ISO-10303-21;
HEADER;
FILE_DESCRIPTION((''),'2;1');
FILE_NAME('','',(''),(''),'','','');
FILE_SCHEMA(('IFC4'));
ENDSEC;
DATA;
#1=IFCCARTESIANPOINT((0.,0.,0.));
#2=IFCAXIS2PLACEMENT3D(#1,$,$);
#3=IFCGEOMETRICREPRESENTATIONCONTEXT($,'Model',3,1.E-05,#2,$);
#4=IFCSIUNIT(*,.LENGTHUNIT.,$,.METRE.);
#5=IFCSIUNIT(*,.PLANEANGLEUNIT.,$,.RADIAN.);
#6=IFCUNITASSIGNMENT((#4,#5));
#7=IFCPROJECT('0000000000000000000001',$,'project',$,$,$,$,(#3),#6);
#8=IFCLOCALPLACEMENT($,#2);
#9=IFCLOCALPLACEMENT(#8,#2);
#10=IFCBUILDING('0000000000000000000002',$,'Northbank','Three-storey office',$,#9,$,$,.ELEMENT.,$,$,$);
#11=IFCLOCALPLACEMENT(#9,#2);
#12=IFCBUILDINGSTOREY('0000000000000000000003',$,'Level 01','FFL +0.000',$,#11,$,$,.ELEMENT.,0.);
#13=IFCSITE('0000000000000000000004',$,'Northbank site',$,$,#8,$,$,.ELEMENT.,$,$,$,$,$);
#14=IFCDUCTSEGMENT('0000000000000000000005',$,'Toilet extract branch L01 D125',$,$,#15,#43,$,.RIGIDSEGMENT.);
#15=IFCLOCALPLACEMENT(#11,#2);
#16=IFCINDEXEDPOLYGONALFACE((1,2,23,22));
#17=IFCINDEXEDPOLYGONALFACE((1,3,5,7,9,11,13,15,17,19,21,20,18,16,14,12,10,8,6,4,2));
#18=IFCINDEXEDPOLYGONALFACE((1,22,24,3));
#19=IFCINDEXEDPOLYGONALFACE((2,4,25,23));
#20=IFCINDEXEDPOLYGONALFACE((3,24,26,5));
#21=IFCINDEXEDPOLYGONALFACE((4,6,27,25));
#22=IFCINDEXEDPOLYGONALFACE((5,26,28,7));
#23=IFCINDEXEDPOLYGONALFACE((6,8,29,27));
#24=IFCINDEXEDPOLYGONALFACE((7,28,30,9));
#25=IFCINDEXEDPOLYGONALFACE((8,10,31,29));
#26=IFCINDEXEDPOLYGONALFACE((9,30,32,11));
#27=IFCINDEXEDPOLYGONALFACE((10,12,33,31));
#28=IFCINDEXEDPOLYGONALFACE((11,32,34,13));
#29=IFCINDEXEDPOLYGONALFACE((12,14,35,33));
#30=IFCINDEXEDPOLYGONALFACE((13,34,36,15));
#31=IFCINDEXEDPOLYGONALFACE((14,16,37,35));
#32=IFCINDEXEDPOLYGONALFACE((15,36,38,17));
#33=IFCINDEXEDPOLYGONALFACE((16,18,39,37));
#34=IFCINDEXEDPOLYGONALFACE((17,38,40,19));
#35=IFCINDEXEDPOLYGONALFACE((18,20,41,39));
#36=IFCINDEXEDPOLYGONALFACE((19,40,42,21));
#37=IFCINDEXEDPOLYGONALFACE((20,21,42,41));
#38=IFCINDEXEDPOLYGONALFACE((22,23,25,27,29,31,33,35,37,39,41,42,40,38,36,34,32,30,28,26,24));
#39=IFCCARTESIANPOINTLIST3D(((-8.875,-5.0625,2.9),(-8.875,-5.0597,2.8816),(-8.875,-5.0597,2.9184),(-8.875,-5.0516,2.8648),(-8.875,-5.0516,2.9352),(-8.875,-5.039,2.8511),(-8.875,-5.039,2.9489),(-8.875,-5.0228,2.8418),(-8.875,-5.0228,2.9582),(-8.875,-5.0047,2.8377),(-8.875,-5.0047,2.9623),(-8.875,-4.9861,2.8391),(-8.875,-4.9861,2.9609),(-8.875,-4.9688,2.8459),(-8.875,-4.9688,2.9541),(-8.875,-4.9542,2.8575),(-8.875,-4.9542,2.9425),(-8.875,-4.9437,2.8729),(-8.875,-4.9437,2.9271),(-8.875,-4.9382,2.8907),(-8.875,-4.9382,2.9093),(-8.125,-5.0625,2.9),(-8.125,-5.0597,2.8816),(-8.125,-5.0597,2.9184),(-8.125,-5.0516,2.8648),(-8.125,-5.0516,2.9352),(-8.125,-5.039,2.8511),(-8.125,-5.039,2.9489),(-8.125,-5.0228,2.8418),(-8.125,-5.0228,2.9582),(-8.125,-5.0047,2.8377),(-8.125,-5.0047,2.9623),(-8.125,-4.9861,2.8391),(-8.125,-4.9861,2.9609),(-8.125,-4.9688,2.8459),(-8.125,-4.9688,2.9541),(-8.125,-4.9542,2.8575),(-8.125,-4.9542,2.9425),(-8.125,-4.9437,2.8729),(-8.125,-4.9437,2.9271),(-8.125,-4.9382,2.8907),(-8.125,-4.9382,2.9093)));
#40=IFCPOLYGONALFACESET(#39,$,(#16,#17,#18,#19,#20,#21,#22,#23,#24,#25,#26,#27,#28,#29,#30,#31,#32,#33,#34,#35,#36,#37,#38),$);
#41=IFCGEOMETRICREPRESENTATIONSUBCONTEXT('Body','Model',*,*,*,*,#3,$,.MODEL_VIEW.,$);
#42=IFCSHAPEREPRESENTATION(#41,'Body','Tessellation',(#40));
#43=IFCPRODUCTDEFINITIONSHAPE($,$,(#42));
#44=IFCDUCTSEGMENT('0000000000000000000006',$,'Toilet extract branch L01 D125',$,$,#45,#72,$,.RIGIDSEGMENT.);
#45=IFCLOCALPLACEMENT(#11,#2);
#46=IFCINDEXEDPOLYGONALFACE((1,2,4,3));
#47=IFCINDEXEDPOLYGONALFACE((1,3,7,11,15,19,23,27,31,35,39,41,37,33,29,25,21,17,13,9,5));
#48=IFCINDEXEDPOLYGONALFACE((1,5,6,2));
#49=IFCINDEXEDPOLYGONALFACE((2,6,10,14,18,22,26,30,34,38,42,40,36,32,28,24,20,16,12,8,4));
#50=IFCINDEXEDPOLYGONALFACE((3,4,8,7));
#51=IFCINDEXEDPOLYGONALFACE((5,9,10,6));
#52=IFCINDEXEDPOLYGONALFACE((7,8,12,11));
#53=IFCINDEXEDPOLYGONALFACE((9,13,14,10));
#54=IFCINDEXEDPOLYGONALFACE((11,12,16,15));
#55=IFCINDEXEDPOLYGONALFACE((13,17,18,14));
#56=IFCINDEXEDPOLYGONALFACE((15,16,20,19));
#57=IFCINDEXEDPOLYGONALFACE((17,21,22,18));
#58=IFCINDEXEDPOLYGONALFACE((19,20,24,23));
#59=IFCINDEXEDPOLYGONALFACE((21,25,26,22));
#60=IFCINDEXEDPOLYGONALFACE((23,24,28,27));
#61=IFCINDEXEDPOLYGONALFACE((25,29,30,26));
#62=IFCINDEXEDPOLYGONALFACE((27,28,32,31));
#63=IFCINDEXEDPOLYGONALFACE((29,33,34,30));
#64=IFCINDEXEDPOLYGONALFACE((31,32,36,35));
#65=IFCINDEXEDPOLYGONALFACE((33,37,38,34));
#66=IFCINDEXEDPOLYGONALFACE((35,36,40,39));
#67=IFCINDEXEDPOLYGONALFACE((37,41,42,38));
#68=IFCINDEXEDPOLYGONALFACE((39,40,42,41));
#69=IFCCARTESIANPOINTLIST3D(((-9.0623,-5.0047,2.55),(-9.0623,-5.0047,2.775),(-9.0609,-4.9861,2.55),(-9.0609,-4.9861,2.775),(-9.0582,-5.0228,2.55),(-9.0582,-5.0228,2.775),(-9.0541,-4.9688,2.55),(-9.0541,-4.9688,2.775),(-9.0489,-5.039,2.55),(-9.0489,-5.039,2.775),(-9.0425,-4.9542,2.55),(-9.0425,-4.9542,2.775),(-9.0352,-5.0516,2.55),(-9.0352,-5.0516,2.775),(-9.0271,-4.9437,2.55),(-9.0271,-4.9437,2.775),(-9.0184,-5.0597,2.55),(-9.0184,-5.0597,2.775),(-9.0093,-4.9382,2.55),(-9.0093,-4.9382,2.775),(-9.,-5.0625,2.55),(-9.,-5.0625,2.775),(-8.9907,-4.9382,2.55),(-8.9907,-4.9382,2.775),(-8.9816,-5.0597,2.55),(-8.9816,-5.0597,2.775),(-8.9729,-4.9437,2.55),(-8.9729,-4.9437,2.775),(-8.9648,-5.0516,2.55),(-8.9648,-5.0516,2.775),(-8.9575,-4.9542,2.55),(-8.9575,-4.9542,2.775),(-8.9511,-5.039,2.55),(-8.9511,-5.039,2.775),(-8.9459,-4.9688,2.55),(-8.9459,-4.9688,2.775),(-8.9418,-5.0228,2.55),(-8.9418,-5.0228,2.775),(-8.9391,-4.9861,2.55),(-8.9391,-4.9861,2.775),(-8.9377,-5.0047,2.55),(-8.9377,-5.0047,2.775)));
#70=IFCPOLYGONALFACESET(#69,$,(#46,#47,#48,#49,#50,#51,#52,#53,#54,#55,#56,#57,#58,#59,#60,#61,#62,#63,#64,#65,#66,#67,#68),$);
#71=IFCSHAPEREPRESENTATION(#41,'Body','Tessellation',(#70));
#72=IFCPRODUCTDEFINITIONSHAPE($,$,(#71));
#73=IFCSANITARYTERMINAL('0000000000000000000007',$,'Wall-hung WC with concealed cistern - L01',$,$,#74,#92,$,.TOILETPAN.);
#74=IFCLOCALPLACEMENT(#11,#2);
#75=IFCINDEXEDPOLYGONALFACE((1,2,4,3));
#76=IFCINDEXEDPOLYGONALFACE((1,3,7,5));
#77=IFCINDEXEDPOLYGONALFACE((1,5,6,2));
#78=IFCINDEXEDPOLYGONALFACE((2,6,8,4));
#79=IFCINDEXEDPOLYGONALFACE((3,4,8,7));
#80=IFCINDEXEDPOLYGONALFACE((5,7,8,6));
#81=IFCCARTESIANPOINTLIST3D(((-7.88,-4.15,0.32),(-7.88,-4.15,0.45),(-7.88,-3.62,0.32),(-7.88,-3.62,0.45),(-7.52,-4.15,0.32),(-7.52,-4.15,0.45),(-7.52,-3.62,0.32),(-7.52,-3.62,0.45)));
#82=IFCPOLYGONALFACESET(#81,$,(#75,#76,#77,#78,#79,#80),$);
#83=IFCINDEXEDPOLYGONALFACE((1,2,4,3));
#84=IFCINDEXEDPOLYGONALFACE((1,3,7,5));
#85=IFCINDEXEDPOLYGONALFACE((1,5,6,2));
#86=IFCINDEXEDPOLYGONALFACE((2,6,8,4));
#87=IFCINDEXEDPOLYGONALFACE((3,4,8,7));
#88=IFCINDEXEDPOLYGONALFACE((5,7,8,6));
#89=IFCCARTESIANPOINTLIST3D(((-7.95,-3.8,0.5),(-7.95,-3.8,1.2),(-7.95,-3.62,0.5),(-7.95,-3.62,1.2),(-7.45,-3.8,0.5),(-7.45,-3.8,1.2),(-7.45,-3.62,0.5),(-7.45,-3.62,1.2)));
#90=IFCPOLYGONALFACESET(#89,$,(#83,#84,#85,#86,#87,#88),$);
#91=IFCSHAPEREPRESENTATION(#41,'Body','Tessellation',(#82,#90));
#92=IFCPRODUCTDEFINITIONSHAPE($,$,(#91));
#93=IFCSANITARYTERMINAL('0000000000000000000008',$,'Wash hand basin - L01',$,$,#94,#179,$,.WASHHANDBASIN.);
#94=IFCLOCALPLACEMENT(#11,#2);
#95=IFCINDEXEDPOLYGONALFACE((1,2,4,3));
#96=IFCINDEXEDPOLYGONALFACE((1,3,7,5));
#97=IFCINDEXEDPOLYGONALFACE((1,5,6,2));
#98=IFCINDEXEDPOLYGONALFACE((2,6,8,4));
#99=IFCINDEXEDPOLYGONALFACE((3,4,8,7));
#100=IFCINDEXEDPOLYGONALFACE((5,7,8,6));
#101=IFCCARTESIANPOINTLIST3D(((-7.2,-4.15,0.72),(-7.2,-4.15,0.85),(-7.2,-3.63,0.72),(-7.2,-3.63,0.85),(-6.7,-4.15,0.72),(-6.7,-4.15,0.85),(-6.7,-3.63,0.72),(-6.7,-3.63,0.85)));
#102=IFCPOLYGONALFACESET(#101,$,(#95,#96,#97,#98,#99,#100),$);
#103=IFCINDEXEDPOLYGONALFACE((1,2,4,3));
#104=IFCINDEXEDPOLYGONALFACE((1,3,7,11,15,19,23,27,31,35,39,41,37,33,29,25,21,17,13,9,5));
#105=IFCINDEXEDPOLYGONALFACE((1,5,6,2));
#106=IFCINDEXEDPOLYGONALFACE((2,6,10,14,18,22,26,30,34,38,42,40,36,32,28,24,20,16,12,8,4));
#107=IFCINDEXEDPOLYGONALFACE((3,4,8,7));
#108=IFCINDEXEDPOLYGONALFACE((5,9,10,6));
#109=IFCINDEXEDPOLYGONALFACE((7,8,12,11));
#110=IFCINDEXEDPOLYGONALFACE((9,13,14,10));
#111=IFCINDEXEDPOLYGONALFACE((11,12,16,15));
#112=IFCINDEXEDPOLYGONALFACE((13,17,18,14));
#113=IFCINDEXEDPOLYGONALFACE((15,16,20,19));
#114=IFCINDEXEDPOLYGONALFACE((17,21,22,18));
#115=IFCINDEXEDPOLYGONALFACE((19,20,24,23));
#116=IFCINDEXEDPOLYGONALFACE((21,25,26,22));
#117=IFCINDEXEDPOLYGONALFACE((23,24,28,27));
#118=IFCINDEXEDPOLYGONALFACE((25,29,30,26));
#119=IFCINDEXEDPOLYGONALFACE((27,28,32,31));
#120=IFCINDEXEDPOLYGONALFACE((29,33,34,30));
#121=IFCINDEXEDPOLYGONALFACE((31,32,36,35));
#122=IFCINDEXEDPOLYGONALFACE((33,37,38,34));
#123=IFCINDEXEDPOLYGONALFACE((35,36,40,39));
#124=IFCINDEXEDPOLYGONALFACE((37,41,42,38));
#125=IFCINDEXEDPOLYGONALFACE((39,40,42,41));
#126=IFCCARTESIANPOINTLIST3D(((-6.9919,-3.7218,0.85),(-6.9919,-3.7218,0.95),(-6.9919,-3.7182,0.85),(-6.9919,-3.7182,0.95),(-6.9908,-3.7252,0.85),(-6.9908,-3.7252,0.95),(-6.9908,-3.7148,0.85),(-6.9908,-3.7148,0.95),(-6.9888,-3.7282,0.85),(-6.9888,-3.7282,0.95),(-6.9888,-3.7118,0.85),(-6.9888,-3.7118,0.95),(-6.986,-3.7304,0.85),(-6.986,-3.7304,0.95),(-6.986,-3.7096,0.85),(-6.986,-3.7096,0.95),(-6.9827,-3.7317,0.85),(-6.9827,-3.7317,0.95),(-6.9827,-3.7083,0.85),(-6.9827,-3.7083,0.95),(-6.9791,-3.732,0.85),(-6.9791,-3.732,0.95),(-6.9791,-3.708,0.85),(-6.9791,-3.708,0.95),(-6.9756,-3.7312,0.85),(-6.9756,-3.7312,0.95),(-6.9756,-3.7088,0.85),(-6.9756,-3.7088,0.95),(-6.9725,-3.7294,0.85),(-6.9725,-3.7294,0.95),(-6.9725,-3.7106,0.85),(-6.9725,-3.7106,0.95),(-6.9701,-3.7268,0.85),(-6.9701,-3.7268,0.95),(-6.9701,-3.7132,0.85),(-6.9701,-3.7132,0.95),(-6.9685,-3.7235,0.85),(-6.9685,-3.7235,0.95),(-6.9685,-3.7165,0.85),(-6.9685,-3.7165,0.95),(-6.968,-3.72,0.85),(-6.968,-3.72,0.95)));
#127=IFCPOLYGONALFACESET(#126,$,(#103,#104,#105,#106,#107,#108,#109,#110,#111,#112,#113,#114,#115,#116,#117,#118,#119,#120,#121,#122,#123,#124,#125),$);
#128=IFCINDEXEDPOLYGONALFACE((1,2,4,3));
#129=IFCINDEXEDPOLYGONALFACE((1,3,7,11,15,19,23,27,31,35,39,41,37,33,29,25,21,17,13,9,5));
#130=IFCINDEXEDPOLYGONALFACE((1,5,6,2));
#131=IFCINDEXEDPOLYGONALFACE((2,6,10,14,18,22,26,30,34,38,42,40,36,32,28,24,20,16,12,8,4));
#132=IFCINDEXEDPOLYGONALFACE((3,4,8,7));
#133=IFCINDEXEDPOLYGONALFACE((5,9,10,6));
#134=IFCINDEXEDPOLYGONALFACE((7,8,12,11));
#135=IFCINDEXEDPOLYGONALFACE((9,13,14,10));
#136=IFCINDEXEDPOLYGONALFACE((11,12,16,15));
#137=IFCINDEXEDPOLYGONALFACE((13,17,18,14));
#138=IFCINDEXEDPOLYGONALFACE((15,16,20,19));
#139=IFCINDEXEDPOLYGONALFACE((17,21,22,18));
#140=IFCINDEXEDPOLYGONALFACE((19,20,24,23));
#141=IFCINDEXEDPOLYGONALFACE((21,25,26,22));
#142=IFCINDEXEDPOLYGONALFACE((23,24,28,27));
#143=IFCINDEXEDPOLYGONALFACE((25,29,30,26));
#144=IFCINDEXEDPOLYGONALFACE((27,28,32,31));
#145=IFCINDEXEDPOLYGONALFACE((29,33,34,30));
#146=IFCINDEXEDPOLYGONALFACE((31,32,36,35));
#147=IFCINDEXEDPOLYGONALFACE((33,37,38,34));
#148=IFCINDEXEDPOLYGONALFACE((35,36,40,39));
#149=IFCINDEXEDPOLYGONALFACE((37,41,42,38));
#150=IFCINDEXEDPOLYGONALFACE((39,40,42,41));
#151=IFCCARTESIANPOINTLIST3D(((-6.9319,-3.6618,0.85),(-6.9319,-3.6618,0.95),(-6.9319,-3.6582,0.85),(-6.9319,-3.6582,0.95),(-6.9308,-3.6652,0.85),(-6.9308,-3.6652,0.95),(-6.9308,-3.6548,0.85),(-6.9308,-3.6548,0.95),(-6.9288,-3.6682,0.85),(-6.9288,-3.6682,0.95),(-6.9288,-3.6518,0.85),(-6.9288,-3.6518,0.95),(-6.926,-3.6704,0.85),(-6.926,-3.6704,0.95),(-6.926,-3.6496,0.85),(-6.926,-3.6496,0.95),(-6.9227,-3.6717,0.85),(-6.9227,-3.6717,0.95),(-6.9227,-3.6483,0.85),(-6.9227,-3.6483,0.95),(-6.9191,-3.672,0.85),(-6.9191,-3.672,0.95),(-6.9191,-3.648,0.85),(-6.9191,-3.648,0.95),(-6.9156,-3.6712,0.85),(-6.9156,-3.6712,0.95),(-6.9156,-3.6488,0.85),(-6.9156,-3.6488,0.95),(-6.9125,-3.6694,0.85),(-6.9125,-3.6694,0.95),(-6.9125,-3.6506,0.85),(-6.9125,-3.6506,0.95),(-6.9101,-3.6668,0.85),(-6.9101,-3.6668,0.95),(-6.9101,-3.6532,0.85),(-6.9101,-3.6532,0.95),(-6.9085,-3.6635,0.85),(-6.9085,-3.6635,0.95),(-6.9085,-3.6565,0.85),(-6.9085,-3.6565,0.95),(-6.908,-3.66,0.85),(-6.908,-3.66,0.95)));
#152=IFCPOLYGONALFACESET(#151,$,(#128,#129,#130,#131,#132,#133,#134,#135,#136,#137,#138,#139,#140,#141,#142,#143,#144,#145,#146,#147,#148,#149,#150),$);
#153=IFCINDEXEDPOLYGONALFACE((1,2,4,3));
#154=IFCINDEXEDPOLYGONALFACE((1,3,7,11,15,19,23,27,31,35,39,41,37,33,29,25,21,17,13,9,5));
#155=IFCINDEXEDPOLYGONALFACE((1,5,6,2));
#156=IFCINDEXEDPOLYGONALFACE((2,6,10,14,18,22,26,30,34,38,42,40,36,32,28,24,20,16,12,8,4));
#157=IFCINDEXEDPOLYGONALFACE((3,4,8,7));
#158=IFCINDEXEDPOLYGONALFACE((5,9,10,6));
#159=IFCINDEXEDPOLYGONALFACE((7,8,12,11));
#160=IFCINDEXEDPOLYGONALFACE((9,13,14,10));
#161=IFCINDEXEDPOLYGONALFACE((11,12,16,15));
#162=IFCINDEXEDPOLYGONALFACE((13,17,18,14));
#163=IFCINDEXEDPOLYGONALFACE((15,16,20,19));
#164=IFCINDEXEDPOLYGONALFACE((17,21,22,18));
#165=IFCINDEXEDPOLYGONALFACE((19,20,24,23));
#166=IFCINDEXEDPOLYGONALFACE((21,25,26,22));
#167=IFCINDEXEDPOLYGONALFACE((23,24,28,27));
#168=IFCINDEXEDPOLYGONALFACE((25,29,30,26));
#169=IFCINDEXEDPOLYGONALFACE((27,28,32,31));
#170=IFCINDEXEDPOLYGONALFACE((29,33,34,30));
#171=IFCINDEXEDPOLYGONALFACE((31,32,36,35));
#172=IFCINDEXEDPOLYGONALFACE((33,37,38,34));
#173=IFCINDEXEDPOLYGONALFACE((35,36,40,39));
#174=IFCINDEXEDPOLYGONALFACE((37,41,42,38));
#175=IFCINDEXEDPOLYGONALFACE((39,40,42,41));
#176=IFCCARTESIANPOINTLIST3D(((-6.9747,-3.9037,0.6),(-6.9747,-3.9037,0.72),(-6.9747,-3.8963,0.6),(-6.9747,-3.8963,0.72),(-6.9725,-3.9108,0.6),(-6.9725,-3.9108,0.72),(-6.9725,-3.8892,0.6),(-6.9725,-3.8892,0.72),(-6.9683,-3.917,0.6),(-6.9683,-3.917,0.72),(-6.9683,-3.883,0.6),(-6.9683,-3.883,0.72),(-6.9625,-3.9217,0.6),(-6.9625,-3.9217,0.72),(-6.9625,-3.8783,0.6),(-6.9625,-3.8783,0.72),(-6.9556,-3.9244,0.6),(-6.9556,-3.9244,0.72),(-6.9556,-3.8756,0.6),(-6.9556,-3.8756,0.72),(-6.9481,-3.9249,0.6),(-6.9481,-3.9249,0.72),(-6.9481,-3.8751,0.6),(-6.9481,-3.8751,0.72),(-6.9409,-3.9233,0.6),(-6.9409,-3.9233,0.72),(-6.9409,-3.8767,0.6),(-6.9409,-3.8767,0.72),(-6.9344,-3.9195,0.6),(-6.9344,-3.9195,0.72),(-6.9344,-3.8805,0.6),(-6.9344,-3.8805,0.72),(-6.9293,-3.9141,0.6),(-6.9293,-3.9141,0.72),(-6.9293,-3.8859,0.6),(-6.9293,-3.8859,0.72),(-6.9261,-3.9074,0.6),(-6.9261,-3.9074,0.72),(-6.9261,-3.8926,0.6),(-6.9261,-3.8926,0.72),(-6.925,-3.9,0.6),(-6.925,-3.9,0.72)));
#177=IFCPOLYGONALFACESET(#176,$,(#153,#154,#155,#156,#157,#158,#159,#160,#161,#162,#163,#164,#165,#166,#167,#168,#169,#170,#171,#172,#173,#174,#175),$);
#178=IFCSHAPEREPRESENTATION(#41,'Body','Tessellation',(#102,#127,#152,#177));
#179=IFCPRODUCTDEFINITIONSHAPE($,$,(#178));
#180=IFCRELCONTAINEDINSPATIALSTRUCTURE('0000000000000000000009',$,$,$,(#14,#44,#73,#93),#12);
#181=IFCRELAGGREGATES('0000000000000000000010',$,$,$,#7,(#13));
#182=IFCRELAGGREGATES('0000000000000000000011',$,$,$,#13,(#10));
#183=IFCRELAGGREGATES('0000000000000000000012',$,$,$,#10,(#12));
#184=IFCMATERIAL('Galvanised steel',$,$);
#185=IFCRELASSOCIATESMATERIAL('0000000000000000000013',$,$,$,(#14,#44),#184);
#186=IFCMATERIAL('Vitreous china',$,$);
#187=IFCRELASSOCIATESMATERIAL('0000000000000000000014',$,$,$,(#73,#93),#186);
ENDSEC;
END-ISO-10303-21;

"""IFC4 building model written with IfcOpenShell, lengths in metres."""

from ifc_helpers import new_model, si_unit, frame, origin, place, context, subcontext, project, spatial, rectangle, circle, extrude, material, element, save


model = new_model("IFC4")

# Units and contexts
model_context = context("Model", 3, precision=1e-05, world=origin())
body_context = subcontext(model_context, "Body", "Model", "MODEL_VIEW")
ifc_project = project(units=[si_unit("LENGTHUNIT", "METRE"), si_unit("PLANEANGLEUNIT", "RADIAN")], contexts=[model_context])

# Site, building, storey
site_placement = place(None, origin())
site = spatial("IfcSite", under=ifc_project, at=site_placement, Name="Northbank site", CompositionType="ELEMENT")
building_placement = place(site_placement, origin())
building = spatial("IfcBuilding", under=site, at=building_placement, Name="Northbank", Description="Three-storey office", CompositionType="ELEMENT")
storey_placement = place(building_placement, origin())
storey = spatial("IfcBuildingStorey", under=building, at=storey_placement, Name="Level 01", Description="FFL +0.000", CompositionType="ELEMENT", Elevation=0.0)

# Shared definitions
ifc_material_1 = material(Name="Galvanised steel")

# Duct segments
duct_segment_1_placement = place(storey_placement, origin())
element("IfcDuctSegment", 1, at=duct_segment_1_placement, inside=storey, material=ifc_material_1, Name="Toilet extract branch L01 D125", PredefinedType="RIGIDSEGMENT", context=body_context, shape_type="SweptSolid", body=[
    extrude(circle(Radius=0.0625), frame((-8.125, -5.0, 2.9), z_axis=(-1.0, 0.0, 0.0), x_axis=(0.0, -1.0, 0.0)), (0.0, 0.0, 1.0), 0.75),
])
duct_segment_2_placement = place(storey_placement, origin())
element("IfcDuctSegment", 2, at=duct_segment_2_placement, inside=storey, material=ifc_material_1, Name="Toilet extract branch L01 D125", PredefinedType="RIGIDSEGMENT", context=body_context, shape_type="SweptSolid", body=[
    extrude(circle(Radius=0.0625), frame((-9.0, -5.0, 2.775), z_axis=(0.0, 0.0, -1.0), x_axis=(0.0, -1.0, 0.0)), (0.0, 0.0, 1.0), 0.225),
])

# Sanitary terminals
ifc_material_2 = material(Name="Vitreous china")
sanitary_terminal_1_placement = place(storey_placement, origin())
element("IfcSanitaryTerminal", 3, at=sanitary_terminal_1_placement, inside=storey, material=ifc_material_2, Name="Wall-hung WC with concealed cistern - L01", PredefinedType="TOILETPAN", context=body_context, shape_type="SweptSolid", body=[
    extrude(rectangle(XDim=0.36, YDim=0.53), frame((-7.7, -3.885, 0.32)), (0.0, 0.0, 1.0), 0.13),
    extrude(rectangle(XDim=0.5, YDim=0.18), frame((-7.7, -3.71, 0.5)), (0.0, 0.0, 1.0), 0.7),
])
sanitary_terminal_2_placement = place(storey_placement, origin())
element("IfcSanitaryTerminal", 4, at=sanitary_terminal_2_placement, inside=storey, material=ifc_material_2, Name="Wash hand basin - L01", PredefinedType="WASHHANDBASIN", context=body_context, shape_type="SweptSolid", body=[
    extrude(rectangle(XDim=0.5, YDim=0.52), frame((-6.95, -3.89, 0.72)), (0.0, 0.0, 1.0), 0.13),
    extrude(circle(Radius=0.012), frame((-6.98, -3.72, 0.85), z_axis=(0.0, 0.0, 1.0), x_axis=(1.0, 0.0, 0.0)), (0.0, 0.0, 1.0), 0.1),
    extrude(circle(Radius=0.012), frame((-6.92, -3.66, 0.85), z_axis=(0.0, 0.0, 1.0), x_axis=(1.0, 0.0, 0.0)), (0.0, 0.0, 1.0), 0.1),
    extrude(circle(Radius=0.025), frame((-6.95, -3.9, 0.72), z_axis=(0.0, 0.0, -1.0), x_axis=(1.0, 0.0, 0.0)), (0.0, 0.0, 1.0), 0.12),
])

save(model, "model.ifc")
